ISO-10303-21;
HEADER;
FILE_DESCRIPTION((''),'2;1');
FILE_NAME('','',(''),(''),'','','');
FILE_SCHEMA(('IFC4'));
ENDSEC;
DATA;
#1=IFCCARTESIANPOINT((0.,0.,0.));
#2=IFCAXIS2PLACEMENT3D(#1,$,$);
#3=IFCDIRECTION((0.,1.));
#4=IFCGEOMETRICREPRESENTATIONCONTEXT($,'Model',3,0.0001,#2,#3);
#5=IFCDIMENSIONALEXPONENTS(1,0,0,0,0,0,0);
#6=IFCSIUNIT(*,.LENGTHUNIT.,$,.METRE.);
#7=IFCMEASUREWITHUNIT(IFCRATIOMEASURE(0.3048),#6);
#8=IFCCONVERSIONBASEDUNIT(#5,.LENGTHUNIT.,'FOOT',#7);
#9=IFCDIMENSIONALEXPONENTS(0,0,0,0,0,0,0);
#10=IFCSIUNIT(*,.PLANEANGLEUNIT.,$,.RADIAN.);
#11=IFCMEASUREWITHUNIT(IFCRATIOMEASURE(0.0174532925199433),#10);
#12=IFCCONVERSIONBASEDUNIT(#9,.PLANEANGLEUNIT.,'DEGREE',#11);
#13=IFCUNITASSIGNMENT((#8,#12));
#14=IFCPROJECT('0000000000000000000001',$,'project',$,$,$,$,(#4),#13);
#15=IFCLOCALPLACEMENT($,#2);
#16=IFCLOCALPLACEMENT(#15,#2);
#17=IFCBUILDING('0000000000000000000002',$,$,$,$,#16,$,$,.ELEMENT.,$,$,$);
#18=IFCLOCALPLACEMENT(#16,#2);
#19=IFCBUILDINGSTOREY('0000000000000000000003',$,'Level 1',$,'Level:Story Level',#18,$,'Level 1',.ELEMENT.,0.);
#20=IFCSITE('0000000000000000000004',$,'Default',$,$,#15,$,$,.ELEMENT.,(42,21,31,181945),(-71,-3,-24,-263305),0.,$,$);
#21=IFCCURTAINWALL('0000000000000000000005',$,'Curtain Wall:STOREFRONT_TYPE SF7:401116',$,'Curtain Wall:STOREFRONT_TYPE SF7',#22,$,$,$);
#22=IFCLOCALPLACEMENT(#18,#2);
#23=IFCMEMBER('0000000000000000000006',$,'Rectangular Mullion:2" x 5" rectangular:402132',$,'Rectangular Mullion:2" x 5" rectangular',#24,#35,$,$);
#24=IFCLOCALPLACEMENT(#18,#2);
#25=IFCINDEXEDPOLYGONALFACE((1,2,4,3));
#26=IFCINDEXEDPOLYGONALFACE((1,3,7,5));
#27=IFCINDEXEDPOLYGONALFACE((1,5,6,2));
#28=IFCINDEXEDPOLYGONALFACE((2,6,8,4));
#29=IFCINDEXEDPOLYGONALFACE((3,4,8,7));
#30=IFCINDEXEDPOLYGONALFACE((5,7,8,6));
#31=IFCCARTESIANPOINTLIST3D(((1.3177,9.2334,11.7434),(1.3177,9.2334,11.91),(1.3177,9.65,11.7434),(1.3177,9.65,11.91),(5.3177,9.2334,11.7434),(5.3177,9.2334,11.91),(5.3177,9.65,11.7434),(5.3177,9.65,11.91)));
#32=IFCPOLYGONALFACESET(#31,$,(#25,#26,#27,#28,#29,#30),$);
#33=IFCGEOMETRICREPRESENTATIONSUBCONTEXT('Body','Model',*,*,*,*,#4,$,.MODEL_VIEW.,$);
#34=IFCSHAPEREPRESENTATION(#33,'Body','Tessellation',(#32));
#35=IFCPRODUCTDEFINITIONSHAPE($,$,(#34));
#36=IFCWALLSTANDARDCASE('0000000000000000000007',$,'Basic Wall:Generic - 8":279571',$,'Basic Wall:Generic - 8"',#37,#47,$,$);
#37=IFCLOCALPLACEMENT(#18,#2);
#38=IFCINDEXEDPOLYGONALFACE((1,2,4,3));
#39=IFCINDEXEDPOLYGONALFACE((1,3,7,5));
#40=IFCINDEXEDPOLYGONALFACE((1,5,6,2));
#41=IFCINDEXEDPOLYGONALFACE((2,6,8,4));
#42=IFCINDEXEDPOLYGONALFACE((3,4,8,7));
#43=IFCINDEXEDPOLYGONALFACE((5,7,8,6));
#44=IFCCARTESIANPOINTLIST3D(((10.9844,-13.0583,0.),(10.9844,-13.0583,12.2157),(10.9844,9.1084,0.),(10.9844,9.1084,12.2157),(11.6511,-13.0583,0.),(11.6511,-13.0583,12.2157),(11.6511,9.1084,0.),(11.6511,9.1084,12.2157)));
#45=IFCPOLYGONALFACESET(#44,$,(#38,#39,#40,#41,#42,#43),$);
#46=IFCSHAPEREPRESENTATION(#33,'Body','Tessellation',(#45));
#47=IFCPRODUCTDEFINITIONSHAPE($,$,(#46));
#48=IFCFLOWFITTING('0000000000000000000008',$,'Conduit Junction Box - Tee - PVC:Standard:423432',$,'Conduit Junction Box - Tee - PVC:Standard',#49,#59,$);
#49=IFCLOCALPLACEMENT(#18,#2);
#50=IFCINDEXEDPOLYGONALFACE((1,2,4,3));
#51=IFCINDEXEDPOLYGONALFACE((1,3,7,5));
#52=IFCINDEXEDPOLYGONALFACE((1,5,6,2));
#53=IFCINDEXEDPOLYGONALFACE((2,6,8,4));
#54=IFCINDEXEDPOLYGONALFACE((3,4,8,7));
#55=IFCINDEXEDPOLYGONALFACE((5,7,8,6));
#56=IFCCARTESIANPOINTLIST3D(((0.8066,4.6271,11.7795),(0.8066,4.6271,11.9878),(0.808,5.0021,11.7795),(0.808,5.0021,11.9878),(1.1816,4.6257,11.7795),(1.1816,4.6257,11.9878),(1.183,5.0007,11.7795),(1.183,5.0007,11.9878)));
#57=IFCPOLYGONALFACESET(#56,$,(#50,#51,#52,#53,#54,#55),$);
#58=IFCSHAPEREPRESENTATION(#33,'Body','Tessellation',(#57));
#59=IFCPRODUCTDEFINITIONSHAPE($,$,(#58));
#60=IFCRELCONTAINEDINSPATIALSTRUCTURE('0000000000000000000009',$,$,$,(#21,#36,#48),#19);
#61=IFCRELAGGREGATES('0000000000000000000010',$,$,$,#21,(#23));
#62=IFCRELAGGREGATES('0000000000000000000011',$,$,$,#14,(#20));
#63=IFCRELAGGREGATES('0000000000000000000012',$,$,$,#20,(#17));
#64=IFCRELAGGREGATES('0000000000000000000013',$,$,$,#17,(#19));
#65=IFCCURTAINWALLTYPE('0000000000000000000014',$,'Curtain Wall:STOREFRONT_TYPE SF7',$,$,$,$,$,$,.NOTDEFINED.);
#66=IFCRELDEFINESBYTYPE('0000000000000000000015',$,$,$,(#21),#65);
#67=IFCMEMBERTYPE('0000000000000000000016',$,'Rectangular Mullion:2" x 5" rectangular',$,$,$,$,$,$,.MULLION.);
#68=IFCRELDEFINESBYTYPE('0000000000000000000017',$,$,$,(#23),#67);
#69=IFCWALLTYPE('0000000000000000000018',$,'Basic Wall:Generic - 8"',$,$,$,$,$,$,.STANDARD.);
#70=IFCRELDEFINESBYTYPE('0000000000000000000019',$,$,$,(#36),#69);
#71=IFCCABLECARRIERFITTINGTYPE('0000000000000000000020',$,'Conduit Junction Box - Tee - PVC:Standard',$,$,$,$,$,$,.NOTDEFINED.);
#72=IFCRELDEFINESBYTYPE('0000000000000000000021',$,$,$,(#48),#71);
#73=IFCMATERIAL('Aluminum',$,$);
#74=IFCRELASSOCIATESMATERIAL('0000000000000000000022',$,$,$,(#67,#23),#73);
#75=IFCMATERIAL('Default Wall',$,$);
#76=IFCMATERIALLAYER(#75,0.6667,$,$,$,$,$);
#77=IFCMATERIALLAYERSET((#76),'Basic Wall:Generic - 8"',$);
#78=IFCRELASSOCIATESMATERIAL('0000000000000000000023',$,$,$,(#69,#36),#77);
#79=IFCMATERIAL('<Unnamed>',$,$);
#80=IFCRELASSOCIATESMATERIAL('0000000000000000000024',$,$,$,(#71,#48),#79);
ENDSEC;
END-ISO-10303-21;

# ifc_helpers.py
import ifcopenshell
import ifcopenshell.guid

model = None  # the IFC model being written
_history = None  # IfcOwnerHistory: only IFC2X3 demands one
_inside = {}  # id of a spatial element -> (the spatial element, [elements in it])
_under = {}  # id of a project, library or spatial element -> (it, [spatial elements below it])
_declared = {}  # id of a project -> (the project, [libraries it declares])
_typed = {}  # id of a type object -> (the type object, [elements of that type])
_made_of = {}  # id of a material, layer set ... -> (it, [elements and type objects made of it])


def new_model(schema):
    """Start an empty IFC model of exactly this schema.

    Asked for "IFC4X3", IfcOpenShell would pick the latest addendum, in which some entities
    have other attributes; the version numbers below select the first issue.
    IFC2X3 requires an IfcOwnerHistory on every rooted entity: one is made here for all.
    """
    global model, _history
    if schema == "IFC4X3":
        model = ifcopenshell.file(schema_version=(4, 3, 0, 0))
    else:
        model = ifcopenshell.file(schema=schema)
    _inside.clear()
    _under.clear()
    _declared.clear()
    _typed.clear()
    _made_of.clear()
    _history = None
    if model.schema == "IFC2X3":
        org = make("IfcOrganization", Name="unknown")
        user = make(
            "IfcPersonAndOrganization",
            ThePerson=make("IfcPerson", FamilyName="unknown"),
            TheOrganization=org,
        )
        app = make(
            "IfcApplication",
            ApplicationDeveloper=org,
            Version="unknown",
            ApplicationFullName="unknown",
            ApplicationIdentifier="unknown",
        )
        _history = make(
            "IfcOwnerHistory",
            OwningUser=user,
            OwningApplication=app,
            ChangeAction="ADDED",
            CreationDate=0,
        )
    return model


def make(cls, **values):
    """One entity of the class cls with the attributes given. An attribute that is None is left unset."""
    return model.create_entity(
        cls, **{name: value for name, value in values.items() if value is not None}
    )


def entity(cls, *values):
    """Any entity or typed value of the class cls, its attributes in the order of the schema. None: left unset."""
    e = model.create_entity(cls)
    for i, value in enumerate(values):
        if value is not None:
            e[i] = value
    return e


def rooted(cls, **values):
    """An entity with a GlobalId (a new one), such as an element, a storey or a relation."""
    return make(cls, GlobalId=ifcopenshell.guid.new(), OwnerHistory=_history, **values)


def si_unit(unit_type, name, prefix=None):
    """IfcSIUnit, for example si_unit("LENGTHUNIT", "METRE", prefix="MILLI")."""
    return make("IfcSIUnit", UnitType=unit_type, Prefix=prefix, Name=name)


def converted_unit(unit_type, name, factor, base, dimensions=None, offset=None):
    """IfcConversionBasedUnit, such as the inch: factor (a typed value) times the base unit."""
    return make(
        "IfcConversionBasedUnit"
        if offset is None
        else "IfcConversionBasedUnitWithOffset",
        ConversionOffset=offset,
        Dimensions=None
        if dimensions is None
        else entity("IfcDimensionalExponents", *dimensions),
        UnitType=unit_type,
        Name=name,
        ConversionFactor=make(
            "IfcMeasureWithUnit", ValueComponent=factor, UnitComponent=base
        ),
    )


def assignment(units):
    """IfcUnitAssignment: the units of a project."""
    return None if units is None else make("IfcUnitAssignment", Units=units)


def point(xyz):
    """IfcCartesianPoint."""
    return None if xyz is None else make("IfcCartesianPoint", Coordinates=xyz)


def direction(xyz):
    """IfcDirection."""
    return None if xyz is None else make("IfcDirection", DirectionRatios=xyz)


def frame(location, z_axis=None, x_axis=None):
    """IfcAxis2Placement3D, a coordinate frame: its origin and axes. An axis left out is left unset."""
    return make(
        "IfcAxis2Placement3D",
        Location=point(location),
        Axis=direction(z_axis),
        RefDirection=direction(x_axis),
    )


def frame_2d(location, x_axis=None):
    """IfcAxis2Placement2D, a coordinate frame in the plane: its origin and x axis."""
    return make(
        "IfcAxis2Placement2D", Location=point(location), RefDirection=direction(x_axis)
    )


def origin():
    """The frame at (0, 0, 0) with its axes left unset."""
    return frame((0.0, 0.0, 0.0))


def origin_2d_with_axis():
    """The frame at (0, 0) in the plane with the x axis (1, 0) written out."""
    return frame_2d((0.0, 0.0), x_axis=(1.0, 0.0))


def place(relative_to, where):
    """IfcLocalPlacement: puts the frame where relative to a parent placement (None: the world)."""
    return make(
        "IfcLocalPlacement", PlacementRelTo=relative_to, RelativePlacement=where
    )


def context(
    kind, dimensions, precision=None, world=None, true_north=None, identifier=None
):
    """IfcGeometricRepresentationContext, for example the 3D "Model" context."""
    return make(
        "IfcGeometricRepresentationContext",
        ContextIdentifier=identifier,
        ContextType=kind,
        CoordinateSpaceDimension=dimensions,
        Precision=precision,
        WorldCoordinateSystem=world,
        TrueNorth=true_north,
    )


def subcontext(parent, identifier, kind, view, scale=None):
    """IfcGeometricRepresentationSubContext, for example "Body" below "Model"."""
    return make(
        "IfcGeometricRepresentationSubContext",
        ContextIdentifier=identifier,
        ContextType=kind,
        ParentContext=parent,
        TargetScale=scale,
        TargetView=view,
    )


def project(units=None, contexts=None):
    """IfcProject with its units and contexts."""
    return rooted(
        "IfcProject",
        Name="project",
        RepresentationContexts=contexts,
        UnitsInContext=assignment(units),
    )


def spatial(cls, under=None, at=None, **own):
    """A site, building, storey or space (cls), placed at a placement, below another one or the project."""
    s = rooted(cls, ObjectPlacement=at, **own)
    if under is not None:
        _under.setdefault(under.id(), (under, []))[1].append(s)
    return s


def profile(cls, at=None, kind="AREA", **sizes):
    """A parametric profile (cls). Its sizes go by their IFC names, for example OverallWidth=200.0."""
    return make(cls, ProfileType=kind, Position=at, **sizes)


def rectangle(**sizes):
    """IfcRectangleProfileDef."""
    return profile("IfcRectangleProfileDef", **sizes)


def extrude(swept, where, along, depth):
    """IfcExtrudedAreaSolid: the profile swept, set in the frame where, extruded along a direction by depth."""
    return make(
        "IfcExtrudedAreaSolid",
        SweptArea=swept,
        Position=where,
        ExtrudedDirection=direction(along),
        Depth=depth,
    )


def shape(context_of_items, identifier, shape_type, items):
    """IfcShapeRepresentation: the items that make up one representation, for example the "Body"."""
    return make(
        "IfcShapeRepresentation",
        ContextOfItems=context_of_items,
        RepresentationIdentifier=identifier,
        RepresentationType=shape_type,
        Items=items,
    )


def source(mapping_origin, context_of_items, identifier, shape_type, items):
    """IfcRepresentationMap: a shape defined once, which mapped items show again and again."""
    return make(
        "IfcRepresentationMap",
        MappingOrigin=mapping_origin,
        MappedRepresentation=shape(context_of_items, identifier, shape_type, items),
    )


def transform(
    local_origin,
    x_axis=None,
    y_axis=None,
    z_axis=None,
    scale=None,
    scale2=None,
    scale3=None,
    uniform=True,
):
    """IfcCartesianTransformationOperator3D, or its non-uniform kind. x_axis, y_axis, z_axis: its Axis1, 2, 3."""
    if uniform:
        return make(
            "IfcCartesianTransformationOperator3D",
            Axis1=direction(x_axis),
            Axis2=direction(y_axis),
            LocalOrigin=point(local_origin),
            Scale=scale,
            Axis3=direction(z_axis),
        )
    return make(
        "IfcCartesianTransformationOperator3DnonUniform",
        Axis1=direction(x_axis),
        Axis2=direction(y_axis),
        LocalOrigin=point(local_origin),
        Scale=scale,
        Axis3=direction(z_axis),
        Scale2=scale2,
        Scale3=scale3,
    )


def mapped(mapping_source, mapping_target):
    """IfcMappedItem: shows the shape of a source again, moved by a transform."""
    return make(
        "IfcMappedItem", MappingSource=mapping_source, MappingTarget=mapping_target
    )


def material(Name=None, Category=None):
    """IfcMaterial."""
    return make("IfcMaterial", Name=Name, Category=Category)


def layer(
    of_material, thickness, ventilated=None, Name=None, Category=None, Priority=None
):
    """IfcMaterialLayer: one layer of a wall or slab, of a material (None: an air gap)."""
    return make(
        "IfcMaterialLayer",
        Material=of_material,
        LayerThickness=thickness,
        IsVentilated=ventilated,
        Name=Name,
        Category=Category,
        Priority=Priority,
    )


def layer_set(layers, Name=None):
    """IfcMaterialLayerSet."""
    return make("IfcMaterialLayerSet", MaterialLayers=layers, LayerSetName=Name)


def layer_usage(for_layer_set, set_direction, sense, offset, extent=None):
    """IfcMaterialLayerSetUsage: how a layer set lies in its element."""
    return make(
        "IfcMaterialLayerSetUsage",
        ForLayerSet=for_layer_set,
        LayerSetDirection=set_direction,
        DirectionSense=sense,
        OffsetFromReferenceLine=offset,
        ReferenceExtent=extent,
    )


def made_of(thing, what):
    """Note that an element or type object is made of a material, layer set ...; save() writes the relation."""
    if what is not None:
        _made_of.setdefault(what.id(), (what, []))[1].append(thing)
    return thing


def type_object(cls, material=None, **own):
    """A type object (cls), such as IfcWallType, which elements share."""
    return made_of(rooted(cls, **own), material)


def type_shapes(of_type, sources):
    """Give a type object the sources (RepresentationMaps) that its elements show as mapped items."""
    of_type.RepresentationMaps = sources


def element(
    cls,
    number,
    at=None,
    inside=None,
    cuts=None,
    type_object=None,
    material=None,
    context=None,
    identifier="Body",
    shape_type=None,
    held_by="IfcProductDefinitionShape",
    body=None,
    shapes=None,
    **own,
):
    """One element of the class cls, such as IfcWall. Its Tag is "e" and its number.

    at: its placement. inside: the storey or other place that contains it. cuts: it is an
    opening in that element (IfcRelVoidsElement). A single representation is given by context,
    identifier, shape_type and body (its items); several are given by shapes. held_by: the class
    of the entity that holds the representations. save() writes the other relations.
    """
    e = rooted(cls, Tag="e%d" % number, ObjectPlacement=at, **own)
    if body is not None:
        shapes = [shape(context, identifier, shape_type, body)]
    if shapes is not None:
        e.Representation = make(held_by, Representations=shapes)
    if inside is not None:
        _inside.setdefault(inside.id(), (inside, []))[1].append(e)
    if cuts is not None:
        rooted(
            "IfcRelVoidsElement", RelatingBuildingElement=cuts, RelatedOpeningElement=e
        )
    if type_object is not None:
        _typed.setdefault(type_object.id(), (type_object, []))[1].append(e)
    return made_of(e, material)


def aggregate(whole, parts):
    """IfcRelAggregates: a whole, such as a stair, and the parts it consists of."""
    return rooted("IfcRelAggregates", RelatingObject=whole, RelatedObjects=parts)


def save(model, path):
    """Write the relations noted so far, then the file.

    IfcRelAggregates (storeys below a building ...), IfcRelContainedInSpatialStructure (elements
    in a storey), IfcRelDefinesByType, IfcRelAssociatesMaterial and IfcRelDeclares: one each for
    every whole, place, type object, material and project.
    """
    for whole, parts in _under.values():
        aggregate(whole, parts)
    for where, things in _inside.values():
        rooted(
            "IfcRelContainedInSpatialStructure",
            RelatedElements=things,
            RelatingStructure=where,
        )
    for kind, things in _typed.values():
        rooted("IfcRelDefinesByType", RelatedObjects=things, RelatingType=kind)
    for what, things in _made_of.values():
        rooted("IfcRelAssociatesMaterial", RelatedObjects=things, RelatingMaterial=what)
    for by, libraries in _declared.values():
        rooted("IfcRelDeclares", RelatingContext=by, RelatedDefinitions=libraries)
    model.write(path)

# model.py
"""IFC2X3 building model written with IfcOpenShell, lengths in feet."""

from ifc_helpers import new_model, entity, si_unit, converted_unit, direction, frame, frame_2d, origin, origin_2d_with_axis, place, context, subcontext, project, spatial, rectangle, extrude, source, transform, mapped, material, layer, layer_set, layer_usage, type_object, type_shapes, element, aggregate, save


model = new_model("IFC2X3")

# Units and contexts
model_context = context("Model", 3, precision=0.0001, world=origin(), true_north=direction((0.0, 1.0)))
body_context = subcontext(model_context, "Body", "Model", "MODEL_VIEW")
ifc_project = project(units=[converted_unit("LENGTHUNIT", "FOOT", entity("IfcRatioMeasure", 0.3048), si_unit("LENGTHUNIT", "METRE"), dimensions=[1, 0, 0, 0, 0, 0, 0]), converted_unit("PLANEANGLEUNIT", "DEGREE", entity("IfcRatioMeasure", 0.0174532925199433), si_unit("PLANEANGLEUNIT", "RADIAN"), dimensions=[0, 0, 0, 0, 0, 0, 0])], contexts=[model_context])

# Site, building, storey
site_placement = place(None, origin())
site = spatial("IfcSite", under=ifc_project, at=site_placement, Name="Default", CompositionType="ELEMENT", RefLatitude=(42, 21, 31, 181945), RefLongitude=(-71, -3, -24, -263305), RefElevation=0.0)
building_placement = place(site_placement, origin())
building = spatial("IfcBuilding", under=site, at=building_placement, CompositionType="ELEMENT")
storey_placement = place(building_placement, origin())
storey = spatial("IfcBuildingStorey", under=building, at=storey_placement, Name="Level 1", ObjectType="Level:Story Level", LongName="Level 1", CompositionType="ELEMENT", Elevation=0.0)

# Curtain wall, member
curtain_wall_type = type_object("IfcCurtainWallType", Name="Curtain Wall:STOREFRONT_TYPE SF7", PredefinedType="NOTDEFINED")
curtain_wall_placement = place(storey_placement, origin())
curtain_wall = element("IfcCurtainWall", 1, at=curtain_wall_placement, inside=storey, type_object=curtain_wall_type, Name="Curtain Wall:STOREFRONT_TYPE SF7:401116", ObjectType="Curtain Wall:STOREFRONT_TYPE SF7")
ifc_material_1 = material(Name="Aluminum")
member_type_1 = type_object("IfcMemberType", Name="Rectangular Mullion:2\" x 5\" rectangular", PredefinedType="MULLION", material=ifc_material_1)
shared_shape_1 = source(origin(), body_context, "Body", "SweptSolid", [
    extrude(rectangle(XDim=0.4167, YDim=0.1667, at=origin_2d_with_axis()), frame((-0.0833, 0.0, -4.0), z_axis=(0.0, 0.0, 1.0), x_axis=(0.0, -1.0, 0.0)), (0.0, 0.0, 1.0), 4.0),
])
type_shapes(member_type_1, [shared_shape_1])
member_1_placement = place(curtain_wall_placement, frame((1.3177, 9.4417, 11.91), z_axis=(-1.0, 0.0, 0.0), x_axis=(0.0, 0.0, 1.0)))
member_1 = element("IfcMember", 2, at=member_1_placement, type_object=member_type_1, material=ifc_material_1, Name="Rectangular Mullion:2\" x 5\" rectangular:402132", ObjectType="Rectangular Mullion:2\" x 5\" rectangular", context=body_context, shape_type="MappedRepresentation", body=[
    mapped(shared_shape_1, transform((0.0, 0.0, 0.0), scale=1.0)),
])
aggregate(curtain_wall, [member_1])

# Wall
ifc_material_2 = material(Name="Default Wall")
ifc_layer_1 = layer(ifc_material_2, 0.6667)
ifc_layer_set_1 = layer_set([ifc_layer_1], Name="Basic Wall:Generic - 8\"")
ifc_layer_usage_1 = layer_usage(ifc_layer_set_1, "AXIS2", "NEGATIVE", 0.3333)
wall_type_1 = type_object("IfcWallType", Name="Basic Wall:Generic - 8\"", PredefinedType="STANDARD", material=ifc_layer_set_1)
wall_1_placement = place(storey_placement, frame((11.3177, 9.1084, 0.0), z_axis=(0.0, 0.0, 1.0), x_axis=(0.0, -1.0, 0.0)))
element("IfcWallStandardCase", 3, at=wall_1_placement, inside=storey, type_object=wall_type_1, material=ifc_layer_usage_1, Name="Basic Wall:Generic - 8\":279571", ObjectType="Basic Wall:Generic - 8\"", context=body_context, shape_type="SweptSolid", body=[
    extrude(rectangle(XDim=22.1667, YDim=0.6667, at=frame_2d((11.0833, 0.0), x_axis=(-1.0, 0.0))), origin(), (0.0, 0.0, 1.0), 12.2157),
])

# Shared definitions
ifc_material_3 = material(Name="<Unnamed>")

# Flow fitting
cable_carrier_fitting_type = type_object("IfcCableCarrierFittingType", Name="Conduit Junction Box - Tee - PVC:Standard", PredefinedType="NOTDEFINED", material=ifc_material_3)
shared_shape_2 = source(origin(), body_context, "Body", "SweptSolid", [
    extrude(rectangle(XDim=0.375, YDim=0.375, at=origin_2d_with_axis()), frame((0.0, 0.0, -0.1042), z_axis=(0.0, 0.0, 1.0), x_axis=(-1.0, 0.0, 0.0)), (0.0, 0.0, 1.0), 0.2083),
])
type_shapes(cable_carrier_fitting_type, [shared_shape_2])
flow_fitting_placement = place(storey_placement, frame((0.9948, 4.8139, 11.8837), z_axis=(0.0, 0.0, 1.0), x_axis=(0.999993, -0.003666, 0.0)))
element("IfcFlowFitting", 4, at=flow_fitting_placement, inside=storey, type_object=cable_carrier_fitting_type, material=ifc_material_3, Name="Conduit Junction Box - Tee - PVC:Standard:423432", ObjectType="Conduit Junction Box - Tee - PVC:Standard", context=body_context, shape_type="MappedRepresentation", body=[
    mapped(shared_shape_2, transform((0.0, 0.0, 0.0), scale=1.0)),
])

save(model, "model.ifc")
